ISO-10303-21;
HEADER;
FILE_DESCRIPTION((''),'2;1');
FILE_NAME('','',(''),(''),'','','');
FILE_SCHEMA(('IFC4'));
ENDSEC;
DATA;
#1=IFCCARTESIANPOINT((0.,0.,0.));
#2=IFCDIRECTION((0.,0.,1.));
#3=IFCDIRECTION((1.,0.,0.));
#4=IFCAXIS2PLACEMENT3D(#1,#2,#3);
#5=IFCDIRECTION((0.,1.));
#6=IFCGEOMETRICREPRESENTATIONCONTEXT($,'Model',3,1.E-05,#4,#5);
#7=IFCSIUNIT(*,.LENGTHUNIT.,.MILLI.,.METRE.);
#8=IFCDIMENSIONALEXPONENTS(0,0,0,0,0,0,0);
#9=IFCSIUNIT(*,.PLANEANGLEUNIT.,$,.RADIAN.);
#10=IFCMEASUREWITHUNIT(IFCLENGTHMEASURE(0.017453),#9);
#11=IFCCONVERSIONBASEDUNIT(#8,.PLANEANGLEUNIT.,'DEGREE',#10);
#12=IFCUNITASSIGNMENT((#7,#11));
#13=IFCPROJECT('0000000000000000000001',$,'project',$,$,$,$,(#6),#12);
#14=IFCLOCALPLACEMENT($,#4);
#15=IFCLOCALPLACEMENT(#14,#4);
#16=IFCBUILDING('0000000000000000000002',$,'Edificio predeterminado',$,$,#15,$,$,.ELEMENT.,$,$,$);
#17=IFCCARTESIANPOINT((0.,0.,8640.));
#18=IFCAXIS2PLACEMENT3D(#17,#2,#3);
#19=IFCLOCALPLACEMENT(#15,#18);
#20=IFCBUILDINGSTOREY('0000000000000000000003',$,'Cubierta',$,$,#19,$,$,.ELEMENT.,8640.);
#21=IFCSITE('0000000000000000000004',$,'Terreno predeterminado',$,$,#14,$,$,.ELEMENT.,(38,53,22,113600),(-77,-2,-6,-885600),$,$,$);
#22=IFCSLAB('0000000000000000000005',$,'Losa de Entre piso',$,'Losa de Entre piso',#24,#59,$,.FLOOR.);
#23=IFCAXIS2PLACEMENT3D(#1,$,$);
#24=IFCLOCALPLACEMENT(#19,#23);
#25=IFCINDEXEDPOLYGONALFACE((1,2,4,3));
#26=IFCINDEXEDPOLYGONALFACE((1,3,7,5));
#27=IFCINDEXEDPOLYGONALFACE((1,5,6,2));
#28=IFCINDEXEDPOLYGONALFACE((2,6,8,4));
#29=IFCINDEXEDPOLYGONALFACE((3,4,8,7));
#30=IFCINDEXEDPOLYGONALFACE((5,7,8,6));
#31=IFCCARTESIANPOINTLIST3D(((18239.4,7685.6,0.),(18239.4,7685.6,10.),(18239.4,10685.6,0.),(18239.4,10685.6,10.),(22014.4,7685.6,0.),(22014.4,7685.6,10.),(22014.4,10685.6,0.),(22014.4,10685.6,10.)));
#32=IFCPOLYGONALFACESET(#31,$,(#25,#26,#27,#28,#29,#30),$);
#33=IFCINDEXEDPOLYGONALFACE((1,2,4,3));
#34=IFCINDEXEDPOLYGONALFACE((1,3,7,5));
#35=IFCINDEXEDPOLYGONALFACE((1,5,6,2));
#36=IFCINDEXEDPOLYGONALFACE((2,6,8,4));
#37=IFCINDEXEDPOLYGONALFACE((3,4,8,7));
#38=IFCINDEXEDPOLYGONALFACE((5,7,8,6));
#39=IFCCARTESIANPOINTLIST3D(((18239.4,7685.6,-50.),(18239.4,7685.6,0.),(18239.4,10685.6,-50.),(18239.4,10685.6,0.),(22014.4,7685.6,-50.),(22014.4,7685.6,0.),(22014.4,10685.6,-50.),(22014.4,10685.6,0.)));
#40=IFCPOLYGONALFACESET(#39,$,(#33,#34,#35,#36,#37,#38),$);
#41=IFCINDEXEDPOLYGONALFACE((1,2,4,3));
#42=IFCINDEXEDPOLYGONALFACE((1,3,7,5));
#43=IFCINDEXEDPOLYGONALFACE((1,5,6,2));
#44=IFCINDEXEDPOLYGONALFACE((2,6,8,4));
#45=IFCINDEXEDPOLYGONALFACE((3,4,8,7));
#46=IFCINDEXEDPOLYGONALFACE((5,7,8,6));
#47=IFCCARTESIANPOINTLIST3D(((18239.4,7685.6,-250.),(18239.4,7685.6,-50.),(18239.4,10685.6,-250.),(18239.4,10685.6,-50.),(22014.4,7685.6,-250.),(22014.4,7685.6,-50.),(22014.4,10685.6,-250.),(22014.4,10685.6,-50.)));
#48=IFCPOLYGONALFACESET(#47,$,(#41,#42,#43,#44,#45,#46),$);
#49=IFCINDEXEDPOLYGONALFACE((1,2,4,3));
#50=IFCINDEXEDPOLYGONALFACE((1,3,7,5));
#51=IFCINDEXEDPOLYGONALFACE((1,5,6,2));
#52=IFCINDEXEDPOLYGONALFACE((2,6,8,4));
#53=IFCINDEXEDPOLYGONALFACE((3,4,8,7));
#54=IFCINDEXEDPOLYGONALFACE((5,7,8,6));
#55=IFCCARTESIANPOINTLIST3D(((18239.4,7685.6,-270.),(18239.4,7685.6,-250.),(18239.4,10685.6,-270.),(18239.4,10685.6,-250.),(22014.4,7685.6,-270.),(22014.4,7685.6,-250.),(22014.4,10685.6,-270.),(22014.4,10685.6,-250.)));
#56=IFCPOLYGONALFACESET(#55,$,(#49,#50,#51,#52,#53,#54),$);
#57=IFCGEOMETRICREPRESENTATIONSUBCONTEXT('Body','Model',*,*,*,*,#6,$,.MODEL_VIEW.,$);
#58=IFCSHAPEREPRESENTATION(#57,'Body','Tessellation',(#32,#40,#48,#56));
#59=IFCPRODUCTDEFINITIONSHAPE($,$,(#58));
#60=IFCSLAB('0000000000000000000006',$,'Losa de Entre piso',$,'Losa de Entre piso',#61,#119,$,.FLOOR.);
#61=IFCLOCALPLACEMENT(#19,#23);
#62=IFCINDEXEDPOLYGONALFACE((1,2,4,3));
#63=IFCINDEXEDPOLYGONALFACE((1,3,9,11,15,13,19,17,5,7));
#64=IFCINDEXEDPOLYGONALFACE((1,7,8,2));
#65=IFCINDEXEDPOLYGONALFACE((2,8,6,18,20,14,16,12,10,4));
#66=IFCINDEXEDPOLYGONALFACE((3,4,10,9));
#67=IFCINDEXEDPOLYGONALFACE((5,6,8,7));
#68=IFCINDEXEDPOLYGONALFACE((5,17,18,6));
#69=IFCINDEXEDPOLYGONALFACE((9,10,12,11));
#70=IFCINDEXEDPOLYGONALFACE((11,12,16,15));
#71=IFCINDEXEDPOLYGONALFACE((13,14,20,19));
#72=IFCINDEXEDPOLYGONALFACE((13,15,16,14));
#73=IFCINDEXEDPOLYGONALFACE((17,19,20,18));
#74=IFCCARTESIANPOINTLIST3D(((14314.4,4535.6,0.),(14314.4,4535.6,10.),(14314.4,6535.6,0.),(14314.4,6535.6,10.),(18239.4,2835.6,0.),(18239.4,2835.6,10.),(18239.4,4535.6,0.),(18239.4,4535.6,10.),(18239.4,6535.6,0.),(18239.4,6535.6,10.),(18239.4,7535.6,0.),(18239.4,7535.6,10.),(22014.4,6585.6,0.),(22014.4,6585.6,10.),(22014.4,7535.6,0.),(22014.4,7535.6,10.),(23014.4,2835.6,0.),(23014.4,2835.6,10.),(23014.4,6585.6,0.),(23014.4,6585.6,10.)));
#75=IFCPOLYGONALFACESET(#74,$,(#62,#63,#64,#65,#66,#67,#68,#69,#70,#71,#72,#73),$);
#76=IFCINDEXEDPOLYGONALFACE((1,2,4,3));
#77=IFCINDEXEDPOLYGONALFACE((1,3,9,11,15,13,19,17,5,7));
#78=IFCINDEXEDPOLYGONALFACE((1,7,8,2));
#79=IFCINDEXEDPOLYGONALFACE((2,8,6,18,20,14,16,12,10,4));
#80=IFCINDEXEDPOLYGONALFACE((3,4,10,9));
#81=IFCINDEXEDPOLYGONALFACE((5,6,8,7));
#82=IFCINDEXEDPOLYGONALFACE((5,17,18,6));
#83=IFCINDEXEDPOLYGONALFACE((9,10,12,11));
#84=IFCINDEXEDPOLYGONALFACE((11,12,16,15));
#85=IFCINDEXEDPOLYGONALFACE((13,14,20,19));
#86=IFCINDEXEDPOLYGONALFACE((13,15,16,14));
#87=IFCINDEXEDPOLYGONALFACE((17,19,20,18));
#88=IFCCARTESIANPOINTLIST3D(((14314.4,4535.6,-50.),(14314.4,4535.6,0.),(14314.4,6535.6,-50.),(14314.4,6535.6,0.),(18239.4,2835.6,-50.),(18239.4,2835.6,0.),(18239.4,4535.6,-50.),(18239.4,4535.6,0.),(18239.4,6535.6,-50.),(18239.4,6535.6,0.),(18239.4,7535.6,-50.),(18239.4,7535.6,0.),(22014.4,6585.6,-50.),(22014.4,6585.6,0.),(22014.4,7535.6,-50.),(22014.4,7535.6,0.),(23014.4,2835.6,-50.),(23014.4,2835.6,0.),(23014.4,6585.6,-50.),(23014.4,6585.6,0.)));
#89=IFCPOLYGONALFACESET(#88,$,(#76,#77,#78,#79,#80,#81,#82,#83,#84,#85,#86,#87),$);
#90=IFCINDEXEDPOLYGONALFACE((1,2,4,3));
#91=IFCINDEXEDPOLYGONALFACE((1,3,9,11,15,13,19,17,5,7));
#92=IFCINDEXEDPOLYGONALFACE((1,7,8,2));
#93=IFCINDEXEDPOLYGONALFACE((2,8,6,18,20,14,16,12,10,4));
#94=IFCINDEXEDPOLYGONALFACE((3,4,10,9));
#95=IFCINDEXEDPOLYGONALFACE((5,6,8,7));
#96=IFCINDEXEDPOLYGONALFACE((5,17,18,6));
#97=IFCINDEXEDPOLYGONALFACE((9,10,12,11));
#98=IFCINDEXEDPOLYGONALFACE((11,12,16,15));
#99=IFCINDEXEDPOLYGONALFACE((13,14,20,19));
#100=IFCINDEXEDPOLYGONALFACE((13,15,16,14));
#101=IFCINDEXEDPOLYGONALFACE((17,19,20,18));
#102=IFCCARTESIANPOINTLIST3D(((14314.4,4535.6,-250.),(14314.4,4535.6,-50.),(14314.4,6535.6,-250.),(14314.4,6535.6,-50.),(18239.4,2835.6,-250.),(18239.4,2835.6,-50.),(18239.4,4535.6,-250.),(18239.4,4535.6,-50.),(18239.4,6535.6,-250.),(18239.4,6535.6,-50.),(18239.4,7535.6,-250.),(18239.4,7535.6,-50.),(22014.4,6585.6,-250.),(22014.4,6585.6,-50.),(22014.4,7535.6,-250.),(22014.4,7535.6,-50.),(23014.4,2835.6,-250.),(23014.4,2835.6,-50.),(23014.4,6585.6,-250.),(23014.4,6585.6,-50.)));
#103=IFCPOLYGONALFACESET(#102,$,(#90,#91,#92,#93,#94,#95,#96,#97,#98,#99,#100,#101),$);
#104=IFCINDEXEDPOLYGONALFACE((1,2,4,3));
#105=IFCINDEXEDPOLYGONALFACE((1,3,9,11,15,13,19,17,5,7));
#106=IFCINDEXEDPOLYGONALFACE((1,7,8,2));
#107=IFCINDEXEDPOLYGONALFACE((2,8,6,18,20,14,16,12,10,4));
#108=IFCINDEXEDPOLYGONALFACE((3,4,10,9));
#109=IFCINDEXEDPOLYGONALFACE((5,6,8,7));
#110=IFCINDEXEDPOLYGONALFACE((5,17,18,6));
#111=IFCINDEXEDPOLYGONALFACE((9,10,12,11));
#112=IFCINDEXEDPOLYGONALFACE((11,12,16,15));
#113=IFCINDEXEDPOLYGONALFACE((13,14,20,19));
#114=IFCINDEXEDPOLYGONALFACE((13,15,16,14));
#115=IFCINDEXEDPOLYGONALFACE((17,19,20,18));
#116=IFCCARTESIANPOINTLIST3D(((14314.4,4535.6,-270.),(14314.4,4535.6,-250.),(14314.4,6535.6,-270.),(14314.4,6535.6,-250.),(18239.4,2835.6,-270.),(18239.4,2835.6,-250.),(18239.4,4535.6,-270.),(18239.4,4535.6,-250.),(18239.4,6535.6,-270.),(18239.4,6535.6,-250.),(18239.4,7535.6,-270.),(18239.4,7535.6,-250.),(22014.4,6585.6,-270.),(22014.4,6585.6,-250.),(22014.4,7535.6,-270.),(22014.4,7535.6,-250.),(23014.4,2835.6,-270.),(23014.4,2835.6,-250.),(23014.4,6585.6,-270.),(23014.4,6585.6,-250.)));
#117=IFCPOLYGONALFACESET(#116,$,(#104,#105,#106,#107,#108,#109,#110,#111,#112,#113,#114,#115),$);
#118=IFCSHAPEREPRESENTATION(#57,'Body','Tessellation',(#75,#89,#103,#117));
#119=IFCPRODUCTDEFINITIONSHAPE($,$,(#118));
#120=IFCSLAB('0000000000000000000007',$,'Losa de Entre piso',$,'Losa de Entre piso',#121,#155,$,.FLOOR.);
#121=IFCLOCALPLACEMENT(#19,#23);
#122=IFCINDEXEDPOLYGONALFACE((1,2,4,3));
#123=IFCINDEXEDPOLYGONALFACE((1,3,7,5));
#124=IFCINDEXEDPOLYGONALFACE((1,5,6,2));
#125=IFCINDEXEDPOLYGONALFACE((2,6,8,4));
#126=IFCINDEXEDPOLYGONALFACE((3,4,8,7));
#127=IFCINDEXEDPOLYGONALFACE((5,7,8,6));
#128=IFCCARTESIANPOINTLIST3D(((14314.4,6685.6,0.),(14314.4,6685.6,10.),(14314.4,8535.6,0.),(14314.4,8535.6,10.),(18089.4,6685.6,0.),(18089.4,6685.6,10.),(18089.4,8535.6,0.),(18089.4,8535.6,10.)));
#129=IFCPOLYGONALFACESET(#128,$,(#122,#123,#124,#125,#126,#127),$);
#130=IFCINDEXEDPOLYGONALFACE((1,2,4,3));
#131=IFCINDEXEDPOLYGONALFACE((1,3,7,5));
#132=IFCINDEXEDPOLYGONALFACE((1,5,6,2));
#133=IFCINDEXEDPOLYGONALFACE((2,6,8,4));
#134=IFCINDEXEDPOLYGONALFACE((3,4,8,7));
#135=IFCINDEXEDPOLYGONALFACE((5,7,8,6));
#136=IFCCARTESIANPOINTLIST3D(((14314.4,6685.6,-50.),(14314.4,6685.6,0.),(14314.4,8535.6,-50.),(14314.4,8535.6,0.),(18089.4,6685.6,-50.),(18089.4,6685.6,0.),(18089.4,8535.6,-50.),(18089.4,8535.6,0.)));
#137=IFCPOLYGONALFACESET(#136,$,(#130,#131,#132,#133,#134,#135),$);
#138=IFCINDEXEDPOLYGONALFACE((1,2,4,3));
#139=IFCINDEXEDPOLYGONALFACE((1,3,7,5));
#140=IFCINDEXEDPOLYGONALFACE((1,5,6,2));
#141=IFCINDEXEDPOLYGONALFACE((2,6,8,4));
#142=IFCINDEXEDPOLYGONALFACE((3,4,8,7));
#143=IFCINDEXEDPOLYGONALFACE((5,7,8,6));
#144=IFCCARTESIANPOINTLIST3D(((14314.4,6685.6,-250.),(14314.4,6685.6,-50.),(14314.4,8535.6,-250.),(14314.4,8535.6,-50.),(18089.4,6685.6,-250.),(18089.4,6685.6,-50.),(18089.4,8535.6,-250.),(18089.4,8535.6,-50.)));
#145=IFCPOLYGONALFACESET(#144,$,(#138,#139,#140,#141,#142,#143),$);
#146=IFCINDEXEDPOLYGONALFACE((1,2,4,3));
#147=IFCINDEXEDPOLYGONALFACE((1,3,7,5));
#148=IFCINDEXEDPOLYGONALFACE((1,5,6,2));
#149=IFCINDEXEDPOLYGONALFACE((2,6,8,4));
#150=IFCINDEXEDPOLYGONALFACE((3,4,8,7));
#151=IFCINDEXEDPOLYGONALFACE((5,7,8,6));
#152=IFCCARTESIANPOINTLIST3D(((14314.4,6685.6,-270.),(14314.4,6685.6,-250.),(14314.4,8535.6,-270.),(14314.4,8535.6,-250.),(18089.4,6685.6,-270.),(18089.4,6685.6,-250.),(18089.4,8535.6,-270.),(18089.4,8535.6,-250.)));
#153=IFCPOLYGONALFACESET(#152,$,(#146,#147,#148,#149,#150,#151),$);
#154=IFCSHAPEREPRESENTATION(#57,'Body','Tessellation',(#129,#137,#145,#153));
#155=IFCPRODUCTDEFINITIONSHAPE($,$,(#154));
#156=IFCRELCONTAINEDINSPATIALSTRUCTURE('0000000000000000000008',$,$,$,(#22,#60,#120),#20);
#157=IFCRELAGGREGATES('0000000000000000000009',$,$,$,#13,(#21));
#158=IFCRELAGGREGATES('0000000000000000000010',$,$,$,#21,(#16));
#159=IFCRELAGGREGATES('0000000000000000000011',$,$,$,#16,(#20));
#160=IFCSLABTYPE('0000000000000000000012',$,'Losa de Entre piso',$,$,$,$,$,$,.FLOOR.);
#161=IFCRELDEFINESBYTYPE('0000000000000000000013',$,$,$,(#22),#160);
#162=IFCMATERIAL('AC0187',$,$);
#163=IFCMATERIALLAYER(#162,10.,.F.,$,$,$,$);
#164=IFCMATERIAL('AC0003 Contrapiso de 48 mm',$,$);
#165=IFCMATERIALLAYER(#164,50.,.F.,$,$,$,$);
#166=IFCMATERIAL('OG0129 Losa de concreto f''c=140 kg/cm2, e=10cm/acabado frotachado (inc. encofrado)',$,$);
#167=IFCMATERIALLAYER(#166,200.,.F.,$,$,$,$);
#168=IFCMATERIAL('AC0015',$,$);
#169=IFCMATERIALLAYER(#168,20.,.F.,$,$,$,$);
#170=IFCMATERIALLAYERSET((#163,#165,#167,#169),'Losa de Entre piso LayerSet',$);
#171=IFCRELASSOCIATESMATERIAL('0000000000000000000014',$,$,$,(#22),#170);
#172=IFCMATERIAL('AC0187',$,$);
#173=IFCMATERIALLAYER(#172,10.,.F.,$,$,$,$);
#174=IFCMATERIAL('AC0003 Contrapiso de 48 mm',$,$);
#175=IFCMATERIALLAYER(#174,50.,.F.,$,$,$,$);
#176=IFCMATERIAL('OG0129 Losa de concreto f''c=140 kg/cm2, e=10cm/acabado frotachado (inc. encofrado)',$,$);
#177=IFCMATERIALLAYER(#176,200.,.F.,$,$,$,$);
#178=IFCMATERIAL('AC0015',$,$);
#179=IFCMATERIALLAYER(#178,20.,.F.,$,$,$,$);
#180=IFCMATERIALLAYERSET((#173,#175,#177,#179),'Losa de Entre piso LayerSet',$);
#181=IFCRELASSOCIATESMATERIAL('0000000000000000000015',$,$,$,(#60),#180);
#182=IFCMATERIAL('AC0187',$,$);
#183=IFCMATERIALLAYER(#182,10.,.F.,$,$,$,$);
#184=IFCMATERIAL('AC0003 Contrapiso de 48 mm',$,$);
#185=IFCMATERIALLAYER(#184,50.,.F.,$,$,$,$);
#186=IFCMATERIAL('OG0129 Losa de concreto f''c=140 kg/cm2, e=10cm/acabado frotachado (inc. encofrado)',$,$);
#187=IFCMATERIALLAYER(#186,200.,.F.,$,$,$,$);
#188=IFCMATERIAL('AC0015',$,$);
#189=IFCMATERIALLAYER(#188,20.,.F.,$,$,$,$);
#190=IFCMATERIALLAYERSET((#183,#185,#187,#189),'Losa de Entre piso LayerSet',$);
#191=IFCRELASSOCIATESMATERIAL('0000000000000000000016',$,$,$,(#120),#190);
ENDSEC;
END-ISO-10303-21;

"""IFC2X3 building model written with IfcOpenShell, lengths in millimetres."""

from ifc_helpers import new_model, entity, si_unit, converted_unit, direction, frame, origin_with_axes, place, context, subcontext, project, spatial, polyline, outline, extrude, material, layer, layer_set, layer_usage, type_object, element, save


model = new_model("IFC2X3")

# Units and contexts
model_context = context("Model", 3, precision=1e-05, world=origin_with_axes(), true_north=direction((0.0, 1.0)))
body_context = subcontext(model_context, "Body", "Model", "MODEL_VIEW")
ifc_project = project(units=[si_unit("LENGTHUNIT", "METRE", prefix="MILLI"), converted_unit("PLANEANGLEUNIT", "DEGREE", entity("IfcLengthMeasure", 0.017453), si_unit("PLANEANGLEUNIT", "RADIAN"), dimensions=[0, 0, 0, 0, 0, 0, 0])], contexts=[model_context])

# Site, building, storey
site_placement = place(None, origin_with_axes())
site = spatial("IfcSite", under=ifc_project, at=site_placement, Name="Terreno predeterminado", CompositionType="ELEMENT", RefLatitude=(38, 53, 22, 113600), RefLongitude=(-77, -2, -6, -885600))
building_placement = place(site_placement, origin_with_axes())
building = spatial("IfcBuilding", under=site, at=building_placement, Name="Edificio predeterminado", CompositionType="ELEMENT")
storey_placement = place(building_placement, frame((0.0, 0.0, 8640.0), z_axis=(0.0, 0.0, 1.0), x_axis=(1.0, 0.0, 0.0)))
storey = spatial("IfcBuildingStorey", under=building, at=storey_placement, Name="Cubierta", CompositionType="ELEMENT", Elevation=8640.0)

# Slabs
ifc_material_1 = material(Name="AC0187")
ifc_layer_1 = layer(ifc_material_1, 10.0, ventilated=False)
ifc_material_2 = material(Name="AC0003 Contrapiso de 48 mm")
ifc_layer_2 = layer(ifc_material_2, 50.0, ventilated=False)
ifc_material_3 = material(Name="OG0129 Losa de concreto f'c=140 kg/cm2, e=10cm/acabado frotachado (inc. encofrado)")
ifc_layer_3 = layer(ifc_material_3, 200.0, ventilated=False)
ifc_material_4 = material(Name="AC0015")
ifc_layer_4 = layer(ifc_material_4, 20.0, ventilated=False)
ifc_layer_set_1 = layer_set([ifc_layer_1, ifc_layer_2, ifc_layer_3, ifc_layer_4], Name="Losa de Entre piso LayerSet")
ifc_layer_usage_1 = layer_usage(ifc_layer_set_1, "AXIS3", "NEGATIVE", 0.0)
slab_type = type_object("IfcSlabType", Name="Losa de Entre piso", PredefinedType="FLOOR")
slab_1_placement = place(storey_placement, frame((0.0, 0.0, -8640.0), z_axis=(0.0, 0.0, 1.0), x_axis=(1.0, 0.0, 0.0)))
element("IfcSlab", 1, at=slab_1_placement, inside=storey, type_object=slab_type, material=ifc_layer_usage_1, Name="Losa de Entre piso", ObjectType="Losa de Entre piso", PredefinedType="FLOOR", context=body_context, shape_type="SweptSolid", body=[
    extrude(outline(polyline([(0.0, 3000.0), (3775.0, 3000.0), (3775.0, 0.0), (0.0, 0.0), (0.0, 3000.0)])), frame((22014.4, 7685.6, 8640.0), z_axis=(0.0, 0.0, -1.0), x_axis=(-1.0, 0.0, 0.0)), (0.0, 0.0, -1.0), 10.0),
    extrude(outline(polyline([(0.0, 3000.0), (3775.0, 3000.0), (3775.0, 0.0), (0.0, 0.0), (0.0, 3000.0)])), frame((22014.4, 7685.6, 8590.0), z_axis=(0.0, 0.0, -1.0), x_axis=(-1.0, 0.0, 0.0)), (0.0, 0.0, -1.0), 50.0),
    extrude(outline(polyline([(0.0, 3000.0), (3775.0, 3000.0), (3775.0, 0.0), (0.0, 0.0), (0.0, 3000.0)])), frame((22014.4, 7685.6, 8390.0), z_axis=(0.0, 0.0, -1.0), x_axis=(-1.0, 0.0, 0.0)), (0.0, 0.0, -1.0), 200.0),
    extrude(outline(polyline([(0.0, 3000.0), (3775.0, 3000.0), (3775.0, 0.0), (0.0, 0.0), (0.0, 3000.0)])), frame((22014.4, 7685.6, 8370.0), z_axis=(0.0, 0.0, -1.0), x_axis=(-1.0, 0.0, 0.0)), (0.0, 0.0, -1.0), 20.0),
])
ifc_material_5 = material(Name="AC0187")
ifc_layer_5 = layer(ifc_material_5, 10.0, ventilated=False)
ifc_material_6 = material(Name="AC0003 Contrapiso de 48 mm")
ifc_layer_6 = layer(ifc_material_6, 50.0, ventilated=False)
ifc_material_7 = material(Name="OG0129 Losa de concreto f'c=140 kg/cm2, e=10cm/acabado frotachado (inc. encofrado)")
ifc_layer_7 = layer(ifc_material_7, 200.0, ventilated=False)
ifc_material_8 = material(Name="AC0015")
ifc_layer_8 = layer(ifc_material_8, 20.0, ventilated=False)
ifc_layer_set_2 = layer_set([ifc_layer_5, ifc_layer_6, ifc_layer_7, ifc_layer_8], Name="Losa de Entre piso LayerSet")
ifc_layer_usage_2 = layer_usage(ifc_layer_set_2, "AXIS3", "NEGATIVE", 0.0)
slab_2_placement = place(storey_placement, frame((0.0, 0.0, -8640.0), z_axis=(0.0, 0.0, 1.0), x_axis=(1.0, 0.0, 0.0)))
element("IfcSlab", 2, at=slab_2_placement, inside=storey, material=ifc_layer_usage_2, Name="Losa de Entre piso", ObjectType="Losa de Entre piso", PredefinedType="FLOOR", context=body_context, shape_type="SweptSolid", body=[
    extrude(outline(polyline([(0.0, 1000.0), (-3925.0, 1000.0), (-3925.0, 3000.0), (0.0, 3000.0), (0.0, 4700.0), (4775.0, 4700.0), (4775.0, 950.0), (3775.0, 950.0), (3775.0, 0.0), (0.0, 0.0), (0.0, 1000.0)])), frame((18239.4, 7535.6, 8640.0), z_axis=(0.0, 0.0, -1.0), x_axis=(1.0, 0.0, 0.0)), (0.0, 0.0, -1.0), 10.0),
    extrude(outline(polyline([(0.0, 1000.0), (-3925.0, 1000.0), (-3925.0, 3000.0), (0.0, 3000.0), (0.0, 4700.0), (4775.0, 4700.0), (4775.0, 950.0), (3775.0, 950.0), (3775.0, 0.0), (0.0, 0.0), (0.0, 1000.0)])), frame((18239.4, 7535.6, 8590.0), z_axis=(0.0, 0.0, -1.0), x_axis=(1.0, 0.0, 0.0)), (0.0, 0.0, -1.0), 50.0),
    extrude(outline(polyline([(0.0, 1000.0), (-3925.0, 1000.0), (-3925.0, 3000.0), (0.0, 3000.0), (0.0, 4700.0), (4775.0, 4700.0), (4775.0, 950.0), (3775.0, 950.0), (3775.0, 0.0), (0.0, 0.0), (0.0, 1000.0)])), frame((18239.4, 7535.6, 8390.0), z_axis=(0.0, 0.0, -1.0), x_axis=(1.0, 0.0, 0.0)), (0.0, 0.0, -1.0), 200.0),
    extrude(outline(polyline([(0.0, 1000.0), (-3925.0, 1000.0), (-3925.0, 3000.0), (0.0, 3000.0), (0.0, 4700.0), (4775.0, 4700.0), (4775.0, 950.0), (3775.0, 950.0), (3775.0, 0.0), (0.0, 0.0), (0.0, 1000.0)])), frame((18239.4, 7535.6, 8370.0), z_axis=(0.0, 0.0, -1.0), x_axis=(1.0, 0.0, 0.0)), (0.0, 0.0, -1.0), 20.0),
])
ifc_material_9 = material(Name="AC0187")
ifc_layer_9 = layer(ifc_material_9, 10.0, ventilated=False)
ifc_material_10 = material(Name="AC0003 Contrapiso de 48 mm")
ifc_layer_10 = layer(ifc_material_10, 50.0, ventilated=False)
ifc_material_11 = material(Name="OG0129 Losa de concreto f'c=140 kg/cm2, e=10cm/acabado frotachado (inc. encofrado)")
ifc_layer_11 = layer(ifc_material_11, 200.0, ventilated=False)
ifc_material_12 = material(Name="AC0015")
ifc_layer_12 = layer(ifc_material_12, 20.0, ventilated=False)
ifc_layer_set_3 = layer_set([ifc_layer_9, ifc_layer_10, ifc_layer_11, ifc_layer_12], Name="Losa de Entre piso LayerSet")
ifc_layer_usage_3 = layer_usage(ifc_layer_set_3, "AXIS3", "NEGATIVE", 0.0)
slab_3_placement = place(storey_placement, frame((0.0, 0.0, -8640.0), z_axis=(0.0, 0.0, 1.0), x_axis=(1.0, 0.0, 0.0)))
element("IfcSlab", 3, at=slab_3_placement, inside=storey, material=ifc_layer_usage_3, Name="Losa de Entre piso", ObjectType="Losa de Entre piso", PredefinedType="FLOOR", context=body_context, shape_type="SweptSolid", body=[
    extrude(outline(polyline([(0.0, 1850.0), (3775.0, 1850.0), (3775.0, 0.0), (0.0, 0.0), (0.0, 1850.0)])), frame((18089.4, 6685.6, 8640.0), z_axis=(0.0, 0.0, -1.0), x_axis=(-1.0, 0.0, 0.0)), (0.0, 0.0, -1.0), 10.0),
    extrude(outline(polyline([(0.0, 1850.0), (3775.0, 1850.0), (3775.0, 0.0), (0.0, 0.0), (0.0, 1850.0)])), frame((18089.4, 6685.6, 8590.0), z_axis=(0.0, 0.0, -1.0), x_axis=(-1.0, 0.0, 0.0)), (0.0, 0.0, -1.0), 50.0),
    extrude(outline(polyline([(0.0, 1850.0), (3775.0, 1850.0), (3775.0, 0.0), (0.0, 0.0), (0.0, 1850.0)])), frame((18089.4, 6685.6, 8390.0), z_axis=(0.0, 0.0, -1.0), x_axis=(-1.0, 0.0, 0.0)), (0.0, 0.0, -1.0), 200.0),
    extrude(outline(polyline([(0.0, 1850.0), (3775.0, 1850.0), (3775.0, 0.0), (0.0, 0.0), (0.0, 1850.0)])), frame((18089.4, 6685.6, 8370.0), z_axis=(0.0, 0.0, -1.0), x_axis=(-1.0, 0.0, 0.0)), (0.0, 0.0, -1.0), 20.0),
])

save(model, "model.ifc")
